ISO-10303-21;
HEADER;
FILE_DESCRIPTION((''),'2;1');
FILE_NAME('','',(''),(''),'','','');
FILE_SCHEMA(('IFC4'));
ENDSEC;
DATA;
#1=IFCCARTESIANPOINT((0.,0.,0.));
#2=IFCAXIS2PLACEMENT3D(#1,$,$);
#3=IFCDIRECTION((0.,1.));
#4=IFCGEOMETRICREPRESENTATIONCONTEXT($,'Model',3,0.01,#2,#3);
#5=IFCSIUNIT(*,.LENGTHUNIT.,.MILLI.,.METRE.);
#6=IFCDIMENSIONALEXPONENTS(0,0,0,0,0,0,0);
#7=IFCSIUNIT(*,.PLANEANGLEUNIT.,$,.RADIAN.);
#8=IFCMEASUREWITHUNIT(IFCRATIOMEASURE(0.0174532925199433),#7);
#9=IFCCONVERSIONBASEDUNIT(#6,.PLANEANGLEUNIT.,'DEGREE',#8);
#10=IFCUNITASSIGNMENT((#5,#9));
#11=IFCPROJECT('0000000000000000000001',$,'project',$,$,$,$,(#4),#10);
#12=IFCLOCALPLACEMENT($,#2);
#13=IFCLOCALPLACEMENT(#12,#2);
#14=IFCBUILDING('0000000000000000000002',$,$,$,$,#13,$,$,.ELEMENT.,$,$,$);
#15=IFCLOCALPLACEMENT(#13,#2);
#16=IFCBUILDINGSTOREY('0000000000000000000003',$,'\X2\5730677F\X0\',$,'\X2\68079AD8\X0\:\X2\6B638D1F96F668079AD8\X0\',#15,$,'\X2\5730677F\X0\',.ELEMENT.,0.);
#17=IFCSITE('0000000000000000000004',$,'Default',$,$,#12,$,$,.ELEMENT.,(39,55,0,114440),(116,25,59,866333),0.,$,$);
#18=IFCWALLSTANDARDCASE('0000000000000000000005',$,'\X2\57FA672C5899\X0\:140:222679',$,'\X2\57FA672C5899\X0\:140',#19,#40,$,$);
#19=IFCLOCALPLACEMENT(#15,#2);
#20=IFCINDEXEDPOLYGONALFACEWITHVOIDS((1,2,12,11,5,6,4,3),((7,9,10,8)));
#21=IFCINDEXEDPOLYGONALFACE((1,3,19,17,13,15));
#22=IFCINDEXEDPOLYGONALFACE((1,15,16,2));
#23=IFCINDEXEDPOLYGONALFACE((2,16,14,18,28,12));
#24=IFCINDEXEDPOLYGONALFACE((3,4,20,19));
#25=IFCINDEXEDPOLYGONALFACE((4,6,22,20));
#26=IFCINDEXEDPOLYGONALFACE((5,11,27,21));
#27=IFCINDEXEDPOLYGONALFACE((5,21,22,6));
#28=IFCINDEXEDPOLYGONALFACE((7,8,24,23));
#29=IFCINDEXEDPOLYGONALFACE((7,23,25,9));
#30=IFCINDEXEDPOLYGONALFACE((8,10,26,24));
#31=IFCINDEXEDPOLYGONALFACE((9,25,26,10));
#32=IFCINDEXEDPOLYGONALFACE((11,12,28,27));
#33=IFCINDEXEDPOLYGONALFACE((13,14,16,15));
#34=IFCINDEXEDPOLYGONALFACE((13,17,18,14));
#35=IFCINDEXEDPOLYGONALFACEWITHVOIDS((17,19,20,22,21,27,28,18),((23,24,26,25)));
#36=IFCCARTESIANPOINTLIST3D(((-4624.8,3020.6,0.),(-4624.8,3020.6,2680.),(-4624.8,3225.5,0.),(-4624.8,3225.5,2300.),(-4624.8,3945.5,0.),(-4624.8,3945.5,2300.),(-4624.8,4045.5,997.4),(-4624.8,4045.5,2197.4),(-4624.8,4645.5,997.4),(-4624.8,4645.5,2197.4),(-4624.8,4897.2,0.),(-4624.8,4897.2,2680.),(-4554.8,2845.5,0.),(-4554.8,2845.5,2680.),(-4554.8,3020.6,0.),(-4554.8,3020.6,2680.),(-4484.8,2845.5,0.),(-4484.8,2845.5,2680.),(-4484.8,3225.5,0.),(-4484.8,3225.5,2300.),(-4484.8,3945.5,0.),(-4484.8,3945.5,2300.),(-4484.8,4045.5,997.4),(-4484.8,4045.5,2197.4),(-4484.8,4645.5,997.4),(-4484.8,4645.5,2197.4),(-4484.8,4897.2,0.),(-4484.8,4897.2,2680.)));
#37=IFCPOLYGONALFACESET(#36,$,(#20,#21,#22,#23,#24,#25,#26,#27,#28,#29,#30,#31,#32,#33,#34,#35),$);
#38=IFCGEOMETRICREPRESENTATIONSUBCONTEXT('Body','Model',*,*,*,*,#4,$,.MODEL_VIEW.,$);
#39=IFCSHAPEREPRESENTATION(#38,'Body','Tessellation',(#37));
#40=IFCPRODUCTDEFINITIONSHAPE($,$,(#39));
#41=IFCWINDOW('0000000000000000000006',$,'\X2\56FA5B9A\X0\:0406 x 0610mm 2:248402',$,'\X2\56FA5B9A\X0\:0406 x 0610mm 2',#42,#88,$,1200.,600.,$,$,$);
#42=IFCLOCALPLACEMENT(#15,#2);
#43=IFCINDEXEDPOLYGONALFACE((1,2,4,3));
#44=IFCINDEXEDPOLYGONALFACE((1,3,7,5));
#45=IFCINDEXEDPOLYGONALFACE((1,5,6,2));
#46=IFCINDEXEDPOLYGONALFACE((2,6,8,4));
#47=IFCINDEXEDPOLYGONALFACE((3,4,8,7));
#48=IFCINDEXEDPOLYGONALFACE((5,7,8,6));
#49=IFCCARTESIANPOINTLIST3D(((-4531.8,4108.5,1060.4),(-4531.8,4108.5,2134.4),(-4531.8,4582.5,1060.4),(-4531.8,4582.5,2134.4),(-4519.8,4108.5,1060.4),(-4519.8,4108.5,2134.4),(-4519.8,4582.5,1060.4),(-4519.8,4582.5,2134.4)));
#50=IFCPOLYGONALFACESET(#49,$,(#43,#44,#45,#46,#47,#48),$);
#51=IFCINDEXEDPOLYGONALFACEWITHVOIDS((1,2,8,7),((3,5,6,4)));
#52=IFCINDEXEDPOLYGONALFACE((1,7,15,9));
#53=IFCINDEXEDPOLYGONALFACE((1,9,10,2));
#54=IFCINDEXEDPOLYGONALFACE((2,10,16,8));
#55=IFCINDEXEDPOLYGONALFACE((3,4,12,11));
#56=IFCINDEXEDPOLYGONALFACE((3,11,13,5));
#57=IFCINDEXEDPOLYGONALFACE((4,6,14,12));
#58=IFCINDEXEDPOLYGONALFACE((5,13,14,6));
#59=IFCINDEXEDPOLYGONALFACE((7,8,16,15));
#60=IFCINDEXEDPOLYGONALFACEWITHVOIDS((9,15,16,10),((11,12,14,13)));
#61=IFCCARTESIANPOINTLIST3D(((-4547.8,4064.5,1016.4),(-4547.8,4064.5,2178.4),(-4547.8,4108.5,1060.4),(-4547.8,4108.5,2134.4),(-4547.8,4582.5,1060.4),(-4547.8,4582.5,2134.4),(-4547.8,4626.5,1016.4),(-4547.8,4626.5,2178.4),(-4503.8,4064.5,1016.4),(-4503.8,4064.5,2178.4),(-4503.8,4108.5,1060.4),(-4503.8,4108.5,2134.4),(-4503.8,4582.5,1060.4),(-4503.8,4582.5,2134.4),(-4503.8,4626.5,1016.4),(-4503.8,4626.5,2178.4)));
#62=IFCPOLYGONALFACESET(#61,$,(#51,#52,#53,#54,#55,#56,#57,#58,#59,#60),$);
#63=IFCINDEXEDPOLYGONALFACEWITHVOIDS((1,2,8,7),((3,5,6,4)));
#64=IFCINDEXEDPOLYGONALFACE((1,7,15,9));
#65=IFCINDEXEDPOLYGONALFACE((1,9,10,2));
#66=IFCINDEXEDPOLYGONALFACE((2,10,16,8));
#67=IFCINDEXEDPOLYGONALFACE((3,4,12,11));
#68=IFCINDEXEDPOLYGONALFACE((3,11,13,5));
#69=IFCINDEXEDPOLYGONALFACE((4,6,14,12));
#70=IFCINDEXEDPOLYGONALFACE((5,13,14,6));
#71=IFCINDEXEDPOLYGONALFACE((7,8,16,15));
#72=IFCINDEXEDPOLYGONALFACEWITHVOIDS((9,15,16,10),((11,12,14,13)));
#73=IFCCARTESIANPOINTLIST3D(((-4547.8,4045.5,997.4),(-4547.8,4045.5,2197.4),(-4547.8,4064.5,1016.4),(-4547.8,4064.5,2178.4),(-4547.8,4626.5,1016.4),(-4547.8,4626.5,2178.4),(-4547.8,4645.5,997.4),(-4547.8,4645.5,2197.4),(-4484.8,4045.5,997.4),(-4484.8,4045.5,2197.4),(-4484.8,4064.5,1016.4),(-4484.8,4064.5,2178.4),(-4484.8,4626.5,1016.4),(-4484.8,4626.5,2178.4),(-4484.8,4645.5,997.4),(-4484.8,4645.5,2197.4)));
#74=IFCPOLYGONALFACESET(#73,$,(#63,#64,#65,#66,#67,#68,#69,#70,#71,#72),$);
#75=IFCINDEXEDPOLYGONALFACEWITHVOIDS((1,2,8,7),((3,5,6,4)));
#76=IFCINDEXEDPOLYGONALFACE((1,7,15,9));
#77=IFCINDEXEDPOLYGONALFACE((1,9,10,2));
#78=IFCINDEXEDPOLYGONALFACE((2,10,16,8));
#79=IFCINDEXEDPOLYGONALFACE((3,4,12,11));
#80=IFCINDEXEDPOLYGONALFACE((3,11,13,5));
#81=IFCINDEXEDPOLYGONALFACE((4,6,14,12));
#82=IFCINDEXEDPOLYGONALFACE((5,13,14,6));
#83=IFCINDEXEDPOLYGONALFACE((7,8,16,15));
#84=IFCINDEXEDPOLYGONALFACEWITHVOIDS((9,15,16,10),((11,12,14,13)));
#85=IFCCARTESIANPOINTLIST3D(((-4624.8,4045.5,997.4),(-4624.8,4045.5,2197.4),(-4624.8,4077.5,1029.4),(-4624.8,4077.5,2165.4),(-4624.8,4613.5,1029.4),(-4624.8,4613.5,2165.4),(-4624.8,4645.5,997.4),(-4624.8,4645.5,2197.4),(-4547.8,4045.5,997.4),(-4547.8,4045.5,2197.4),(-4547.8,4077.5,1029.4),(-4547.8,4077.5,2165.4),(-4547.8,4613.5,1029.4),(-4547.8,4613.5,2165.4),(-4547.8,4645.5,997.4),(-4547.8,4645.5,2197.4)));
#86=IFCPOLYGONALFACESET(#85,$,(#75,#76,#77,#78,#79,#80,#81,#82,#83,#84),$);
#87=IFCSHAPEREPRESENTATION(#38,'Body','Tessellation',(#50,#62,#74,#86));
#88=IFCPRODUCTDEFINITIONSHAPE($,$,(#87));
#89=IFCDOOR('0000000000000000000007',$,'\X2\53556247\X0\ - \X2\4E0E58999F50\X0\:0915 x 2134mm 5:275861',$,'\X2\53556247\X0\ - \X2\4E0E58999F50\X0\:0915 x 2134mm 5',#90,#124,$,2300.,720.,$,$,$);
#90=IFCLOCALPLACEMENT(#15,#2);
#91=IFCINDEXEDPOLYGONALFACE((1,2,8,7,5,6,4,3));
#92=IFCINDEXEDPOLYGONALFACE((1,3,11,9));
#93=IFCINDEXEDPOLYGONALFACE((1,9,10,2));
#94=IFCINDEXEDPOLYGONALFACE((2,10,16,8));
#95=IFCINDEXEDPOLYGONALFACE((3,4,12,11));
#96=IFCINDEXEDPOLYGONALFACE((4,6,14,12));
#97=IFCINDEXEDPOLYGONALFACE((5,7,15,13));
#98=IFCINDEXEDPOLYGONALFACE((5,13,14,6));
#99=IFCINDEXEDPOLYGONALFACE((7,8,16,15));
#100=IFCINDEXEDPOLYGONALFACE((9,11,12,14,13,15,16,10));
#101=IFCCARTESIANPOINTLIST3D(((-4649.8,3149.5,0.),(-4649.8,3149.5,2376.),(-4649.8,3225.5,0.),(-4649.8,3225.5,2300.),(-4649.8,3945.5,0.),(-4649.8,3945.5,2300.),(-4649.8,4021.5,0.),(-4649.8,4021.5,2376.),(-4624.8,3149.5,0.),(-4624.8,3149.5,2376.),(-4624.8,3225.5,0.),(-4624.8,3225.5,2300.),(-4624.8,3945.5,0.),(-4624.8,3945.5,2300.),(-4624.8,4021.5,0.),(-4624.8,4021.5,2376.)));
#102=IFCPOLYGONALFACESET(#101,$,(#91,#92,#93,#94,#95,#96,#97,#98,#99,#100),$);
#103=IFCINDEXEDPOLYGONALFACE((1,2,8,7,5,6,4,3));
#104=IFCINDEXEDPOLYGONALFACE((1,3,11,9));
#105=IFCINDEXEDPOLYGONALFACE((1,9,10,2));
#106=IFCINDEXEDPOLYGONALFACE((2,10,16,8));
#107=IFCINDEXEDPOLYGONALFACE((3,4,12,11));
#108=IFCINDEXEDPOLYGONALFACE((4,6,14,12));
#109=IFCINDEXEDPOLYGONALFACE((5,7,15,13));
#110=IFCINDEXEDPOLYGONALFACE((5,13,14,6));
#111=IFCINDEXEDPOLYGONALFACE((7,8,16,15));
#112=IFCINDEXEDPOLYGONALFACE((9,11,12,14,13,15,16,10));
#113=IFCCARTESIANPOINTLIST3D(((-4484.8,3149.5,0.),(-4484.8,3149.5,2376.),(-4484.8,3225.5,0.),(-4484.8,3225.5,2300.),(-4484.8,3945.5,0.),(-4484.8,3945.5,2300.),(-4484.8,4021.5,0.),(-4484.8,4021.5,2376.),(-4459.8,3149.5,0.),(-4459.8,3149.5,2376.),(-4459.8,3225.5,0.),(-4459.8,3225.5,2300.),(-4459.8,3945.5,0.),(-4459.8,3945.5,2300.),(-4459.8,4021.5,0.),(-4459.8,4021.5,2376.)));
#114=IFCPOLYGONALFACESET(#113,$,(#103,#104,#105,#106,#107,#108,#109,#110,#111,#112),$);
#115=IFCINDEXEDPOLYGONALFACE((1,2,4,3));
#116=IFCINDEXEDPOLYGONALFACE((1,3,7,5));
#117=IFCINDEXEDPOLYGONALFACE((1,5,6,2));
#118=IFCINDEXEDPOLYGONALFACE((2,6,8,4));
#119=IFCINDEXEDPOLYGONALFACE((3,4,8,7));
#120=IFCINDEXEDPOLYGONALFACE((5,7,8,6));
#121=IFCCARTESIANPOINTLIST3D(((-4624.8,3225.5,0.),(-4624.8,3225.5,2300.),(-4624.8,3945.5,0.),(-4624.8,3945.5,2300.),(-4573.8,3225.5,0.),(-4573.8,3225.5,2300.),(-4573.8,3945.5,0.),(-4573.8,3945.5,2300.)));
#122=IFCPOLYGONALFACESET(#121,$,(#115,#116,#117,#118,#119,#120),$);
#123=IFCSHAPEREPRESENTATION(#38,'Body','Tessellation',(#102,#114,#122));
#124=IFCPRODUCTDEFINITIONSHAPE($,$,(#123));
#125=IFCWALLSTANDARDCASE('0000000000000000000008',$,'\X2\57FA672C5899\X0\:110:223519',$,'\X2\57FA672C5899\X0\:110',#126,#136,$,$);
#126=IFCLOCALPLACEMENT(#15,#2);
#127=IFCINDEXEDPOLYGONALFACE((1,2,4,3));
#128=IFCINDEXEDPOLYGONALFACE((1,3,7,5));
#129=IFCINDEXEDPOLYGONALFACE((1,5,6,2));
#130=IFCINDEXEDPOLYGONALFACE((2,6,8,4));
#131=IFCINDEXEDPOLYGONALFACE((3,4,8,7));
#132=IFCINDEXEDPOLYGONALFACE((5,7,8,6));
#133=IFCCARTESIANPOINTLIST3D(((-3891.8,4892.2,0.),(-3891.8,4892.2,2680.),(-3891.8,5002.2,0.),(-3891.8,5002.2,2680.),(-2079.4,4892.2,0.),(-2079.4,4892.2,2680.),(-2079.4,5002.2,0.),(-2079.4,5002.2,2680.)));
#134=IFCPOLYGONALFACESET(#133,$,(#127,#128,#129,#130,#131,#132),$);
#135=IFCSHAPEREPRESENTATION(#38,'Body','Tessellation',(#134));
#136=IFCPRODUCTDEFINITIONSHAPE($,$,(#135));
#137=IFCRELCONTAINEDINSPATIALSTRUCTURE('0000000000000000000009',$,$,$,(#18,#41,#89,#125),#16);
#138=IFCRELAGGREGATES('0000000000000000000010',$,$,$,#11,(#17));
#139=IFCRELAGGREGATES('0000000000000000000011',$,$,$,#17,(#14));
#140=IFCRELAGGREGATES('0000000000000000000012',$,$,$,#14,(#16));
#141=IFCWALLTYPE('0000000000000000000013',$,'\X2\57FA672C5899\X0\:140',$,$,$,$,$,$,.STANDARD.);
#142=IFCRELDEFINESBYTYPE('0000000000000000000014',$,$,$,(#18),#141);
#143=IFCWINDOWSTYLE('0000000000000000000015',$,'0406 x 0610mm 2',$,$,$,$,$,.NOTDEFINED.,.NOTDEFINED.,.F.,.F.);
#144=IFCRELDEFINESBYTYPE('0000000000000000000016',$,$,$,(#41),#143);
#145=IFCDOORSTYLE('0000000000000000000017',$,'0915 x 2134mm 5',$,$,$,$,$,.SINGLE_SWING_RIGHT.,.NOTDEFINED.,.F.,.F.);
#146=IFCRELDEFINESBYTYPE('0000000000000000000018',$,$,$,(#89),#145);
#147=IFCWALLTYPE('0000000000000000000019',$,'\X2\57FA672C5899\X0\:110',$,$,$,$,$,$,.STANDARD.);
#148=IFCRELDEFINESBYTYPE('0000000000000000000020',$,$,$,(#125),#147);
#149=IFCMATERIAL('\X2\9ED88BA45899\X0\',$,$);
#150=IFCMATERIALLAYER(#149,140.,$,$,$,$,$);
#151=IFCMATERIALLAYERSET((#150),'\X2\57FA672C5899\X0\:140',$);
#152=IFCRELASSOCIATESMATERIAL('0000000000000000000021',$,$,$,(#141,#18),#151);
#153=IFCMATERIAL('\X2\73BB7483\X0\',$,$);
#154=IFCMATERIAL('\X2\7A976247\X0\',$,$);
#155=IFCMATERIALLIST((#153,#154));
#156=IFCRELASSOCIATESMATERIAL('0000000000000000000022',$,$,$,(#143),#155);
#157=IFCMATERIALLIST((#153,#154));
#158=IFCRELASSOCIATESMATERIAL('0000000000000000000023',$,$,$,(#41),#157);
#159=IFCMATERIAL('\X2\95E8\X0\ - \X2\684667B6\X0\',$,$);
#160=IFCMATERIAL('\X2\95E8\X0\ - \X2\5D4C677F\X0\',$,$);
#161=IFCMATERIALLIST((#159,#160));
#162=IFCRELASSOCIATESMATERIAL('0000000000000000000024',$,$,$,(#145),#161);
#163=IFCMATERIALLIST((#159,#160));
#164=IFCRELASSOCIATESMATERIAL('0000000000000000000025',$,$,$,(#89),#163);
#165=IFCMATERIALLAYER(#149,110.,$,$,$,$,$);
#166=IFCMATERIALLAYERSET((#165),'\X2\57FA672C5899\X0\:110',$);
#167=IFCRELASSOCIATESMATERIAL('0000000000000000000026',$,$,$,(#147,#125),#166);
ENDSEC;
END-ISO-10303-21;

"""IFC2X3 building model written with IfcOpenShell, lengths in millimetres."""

from ifc_helpers import new_model, entity, si_unit, converted_unit, direction, frame, frame_2d, origin, origin_2d_with_axis, place, context, subcontext, project, spatial, polyline, rectangle, outline, extrude, source, transform, mapped, material, material_list, layer, layer_set, layer_usage, type_object, type_shapes, element, fill, save


model = new_model("IFC2X3")

# Units and contexts
model_context = context("Model", 3, precision=0.01, world=origin(), true_north=direction((0.0, 1.0)))
body_context = subcontext(model_context, "Body", "Model", "MODEL_VIEW")
ifc_project = project(units=[si_unit("LENGTHUNIT", "METRE", prefix="MILLI"), converted_unit("PLANEANGLEUNIT", "DEGREE", entity("IfcRatioMeasure", 0.0174532925199433), si_unit("PLANEANGLEUNIT", "RADIAN"), dimensions=[0, 0, 0, 0, 0, 0, 0])], contexts=[model_context])

# Site, building, storey
site_placement = place(None, origin())
site = spatial("IfcSite", under=ifc_project, at=site_placement, Name="Default", CompositionType="ELEMENT", RefLatitude=(39, 55, 0, 114440), RefLongitude=(116, 25, 59, 866333), RefElevation=0.0)
building_placement = place(site_placement, origin())
building = spatial("IfcBuilding", under=site, at=building_placement, CompositionType="ELEMENT")
storey_placement = place(building_placement, origin())
storey = spatial("IfcBuildingStorey", under=building, at=storey_placement, Name="地板", ObjectType="标高:正负零标高", LongName="地板", CompositionType="ELEMENT", Elevation=0.0)

# Shared definitions
ifc_material_1 = material(Name="默认墙")

# Shared definitions
ifc_material_2 = material(Name="门 - 框架")
ifc_material_3 = material(Name="门 - 嵌板")

# Wall, openings, window, door
ifc_layer_1 = layer(ifc_material_1, 140.0)
ifc_layer_set_1 = layer_set([ifc_layer_1], Name="基本墙:140")
ifc_layer_usage_1 = layer_usage(ifc_layer_set_1, "AXIS2", "NEGATIVE", 70.0)
wall_type_1 = type_object("IfcWallType", Name="基本墙:140", PredefinedType="STANDARD", material=ifc_layer_set_1)
wall_1_placement = place(storey_placement, frame((-4554.8, 2845.5, 0.0), z_axis=(0.0, 0.0, 1.0), x_axis=(0.0, 1.0, 0.0)))
wall_1 = element("IfcWallStandardCase", 1, at=wall_1_placement, inside=storey, type_object=wall_type_1, material=ifc_layer_usage_1, Name="基本墙:140:222679", ObjectType="基本墙:140", context=body_context, shape_type="SweptSolid", body=[
    extrude(outline(polyline([(0.0, -70.0), (1680.6, -70.0), (1920.6, -70.0), (2051.7, -70.0), (2051.7, 70.0), (175.0, 70.0), (175.0, 0.0), (0.0, 0.0), (0.0, -70.0)])), origin(), (0.0, 0.0, 1.0), 2680.0),
])
opening_1_placement = place(wall_1_placement, frame((380.0, -70.0, 0.0)))
opening_1 = element("IfcOpeningElement", 2, at=opening_1_placement, cuts=wall_1, ObjectType="Opening", context=body_context, shape_type="SweptSolid", body=[
    extrude(rectangle(XDim=720.0, YDim=2300.0, at=frame_2d((1150.0, 360.0), x_axis=(0.0, 1.0))), frame((0.0, 0.0, 0.0), z_axis=(0.0, 1.0, 0.0), x_axis=(0.0, 0.0, 1.0)), (0.0, 0.0, 1.0), 140.0),
])
opening_2_placement = place(wall_1_placement, frame((1800.0, 70.0, 997.4)))
opening_2 = element("IfcOpeningElement", 3, at=opening_2_placement, cuts=wall_1, ObjectType="Opening", context=body_context, shape_type="SweptSolid", body=[
    extrude(rectangle(XDim=1200.0, YDim=600.0, at=frame_2d((600.0, 300.0), x_axis=(1.0, 0.0))), frame((0.0, 0.0, 0.0), z_axis=(0.0, -1.0, 0.0), x_axis=(0.0, 0.0, 1.0)), (0.0, 0.0, 1.0), 140.0),
])
ifc_material_4 = material(Name="玻璃")
ifc_material_5 = material(Name="窗扇")
ifc_material_list_1 = material_list([ifc_material_4, ifc_material_5])
ifc_material_list_2 = material_list([ifc_material_4, ifc_material_5])
window_style = type_object("IfcWindowStyle", Name="0406 x 0610mm 2", ConstructionType="NOTDEFINED", OperationType="NOTDEFINED", ParameterTakesPrecedence=False, Sizeable=False, material=ifc_material_list_2)
shared_shape_1 = source(origin(), body_context, "Body", "SweptSolid", [
    extrude(rectangle(XDim=12.0, YDim=474.0, at=origin_2d_with_axis()), frame((300.0, 99.0, 63.0), z_axis=(0.0, 0.0, 1.0), x_axis=(0.0, -1.0, 0.0)), (0.0, 0.0, 1.0), 1074.0),
    extrude(outline(polyline([(-281.0, -581.0), (281.0, -581.0), (281.0, 581.0), (-281.0, 581.0), (-281.0, -581.0)]), holes=[polyline([(-237.0, -537.0), (-237.0, 537.0), (237.0, 537.0), (237.0, -537.0), (-237.0, -537.0)])]), frame((300.0, 77.0, 600.0), z_axis=(0.0, 1.0, 0.0), x_axis=(1.0, 0.0, 0.0)), (0.0, 0.0, 1.0), 44.0),
    extrude(outline(polyline([(-300.0, -600.0), (300.0, -600.0), (300.0, 600.0), (-300.0, 600.0), (-300.0, -600.0)]), holes=[polyline([(-281.0, -581.0), (-281.0, 581.0), (281.0, 581.0), (281.0, -581.0), (-281.0, -581.0)])]), frame((300.0, 77.0, 600.0), z_axis=(0.0, 1.0, 0.0), x_axis=(1.0, 0.0, 0.0)), (0.0, 0.0, 1.0), 63.0),
    extrude(outline(polyline([(-300.0, -600.0), (300.0, -600.0), (300.0, 600.0), (-300.0, 600.0), (-300.0, -600.0)]), holes=[polyline([(-268.0, -568.0), (-268.0, 568.0), (268.0, 568.0), (268.0, -568.0), (-268.0, -568.0)])]), frame((300.0, 0.0, 600.0), z_axis=(0.0, 1.0, 0.0), x_axis=(1.0, 0.0, 0.0)), (0.0, 0.0, 1.0), 77.0),
])
type_shapes(window_style, [shared_shape_1])
window_placement = place(opening_2_placement, frame((0.0, 0.0, 0.0), z_axis=(0.0, 0.0, 1.0), x_axis=(-1.0, 0.0, 0.0)))
window = element("IfcWindow", 4, at=window_placement, inside=storey, type_object=window_style, material=ifc_material_list_1, Name="固定:0406 x 0610mm 2:248402", ObjectType="固定:0406 x 0610mm 2", OverallHeight=1200.0, OverallWidth=600.0, context=body_context, shape_type="MappedRepresentation", body=[
    mapped(shared_shape_1, transform((0.0, 0.0, 0.0), scale=1.0)),
])
fill(opening_2, window)
ifc_material_list_3 = material_list([ifc_material_2, ifc_material_3])
ifc_material_list_4 = material_list([ifc_material_2, ifc_material_3])
door_style_1 = type_object("IfcDoorStyle", Name="0915 x 2134mm 5", ConstructionType="NOTDEFINED", OperationType="SINGLE_SWING_RIGHT", ParameterTakesPrecedence=False, Sizeable=False, material=ifc_material_list_4)
shared_shape_2 = source(origin(), body_context, "Body", "SweptSolid", [
    extrude(outline(polyline([(-436.0, -1207.0), (436.0, -1207.0), (436.0, 1169.0), (360.0, 1169.0), (360.0, -1131.0), (-360.0, -1131.0), (-360.0, 1169.0), (-436.0, 1169.0), (-436.0, -1207.0)])), frame((360.0, 140.0, 1169.0), z_axis=(0.0, 1.0, 0.0), x_axis=(1.0, 0.0, 0.0)), (0.0, 0.0, 1.0), 25.0),
    extrude(outline(polyline([(-1207.0, -436.0), (1169.0, -436.0), (1169.0, -360.0), (-1131.0, -360.0), (-1131.0, 360.0), (1169.0, 360.0), (1169.0, 436.0), (-1207.0, 436.0), (-1207.0, -436.0)])), frame((360.0, -25.0, 1169.0), z_axis=(0.0, 1.0, 0.0), x_axis=(0.0, 0.0, -1.0)), (0.0, 0.0, 1.0), 25.0),
    extrude(rectangle(XDim=51.0, YDim=720.0, at=frame_2d((0.0, 0.0), x_axis=(1.0, 0.0))), frame((360.0, 114.5, 0.0), z_axis=(0.0, 0.0, 1.0), x_axis=(0.0, 1.0, 0.0)), (0.0, 0.0, 1.0), 2300.0),
])
type_shapes(door_style_1, [shared_shape_2])
door_1_placement = place(opening_1_placement, origin())
door_1 = element("IfcDoor", 5, at=door_1_placement, inside=storey, type_object=door_style_1, material=ifc_material_list_3, Name="单扇 - 与墙齐:0915 x 2134mm 5:275861", ObjectType="单扇 - 与墙齐:0915 x 2134mm 5", OverallHeight=2300.0, OverallWidth=720.0, context=body_context, shape_type="MappedRepresentation", body=[
    mapped(shared_shape_2, transform((0.0, 0.0, 0.0), scale=1.0)),
])
fill(opening_1, door_1)

# Wall
ifc_layer_2 = layer(ifc_material_1, 110.0)
ifc_layer_set_2 = layer_set([ifc_layer_2], Name="基本墙:110")
ifc_layer_usage_2 = layer_usage(ifc_layer_set_2, "AXIS2", "NEGATIVE", 55.0)
wall_type_2 = type_object("IfcWallType", Name="基本墙:110", PredefinedType="STANDARD", material=ifc_layer_set_2)
wall_2_placement = place(storey_placement, frame((-2079.4, 4947.2, 0.0), z_axis=(0.0, 0.0, 1.0), x_axis=(-1.0, 0.0, 0.0)))
element("IfcWallStandardCase", 6, at=wall_2_placement, inside=storey, type_object=wall_type_2, material=ifc_layer_usage_2, Name="基本墙:110:223519", ObjectType="基本墙:110", context=body_context, shape_type="SweptSolid", body=[
    extrude(rectangle(XDim=1812.4, YDim=110.0, at=frame_2d((906.2, 0.0), x_axis=(-1.0, 0.0))), origin(), (0.0, 0.0, 1.0), 2680.0),
])

save(model, "model.ifc")
